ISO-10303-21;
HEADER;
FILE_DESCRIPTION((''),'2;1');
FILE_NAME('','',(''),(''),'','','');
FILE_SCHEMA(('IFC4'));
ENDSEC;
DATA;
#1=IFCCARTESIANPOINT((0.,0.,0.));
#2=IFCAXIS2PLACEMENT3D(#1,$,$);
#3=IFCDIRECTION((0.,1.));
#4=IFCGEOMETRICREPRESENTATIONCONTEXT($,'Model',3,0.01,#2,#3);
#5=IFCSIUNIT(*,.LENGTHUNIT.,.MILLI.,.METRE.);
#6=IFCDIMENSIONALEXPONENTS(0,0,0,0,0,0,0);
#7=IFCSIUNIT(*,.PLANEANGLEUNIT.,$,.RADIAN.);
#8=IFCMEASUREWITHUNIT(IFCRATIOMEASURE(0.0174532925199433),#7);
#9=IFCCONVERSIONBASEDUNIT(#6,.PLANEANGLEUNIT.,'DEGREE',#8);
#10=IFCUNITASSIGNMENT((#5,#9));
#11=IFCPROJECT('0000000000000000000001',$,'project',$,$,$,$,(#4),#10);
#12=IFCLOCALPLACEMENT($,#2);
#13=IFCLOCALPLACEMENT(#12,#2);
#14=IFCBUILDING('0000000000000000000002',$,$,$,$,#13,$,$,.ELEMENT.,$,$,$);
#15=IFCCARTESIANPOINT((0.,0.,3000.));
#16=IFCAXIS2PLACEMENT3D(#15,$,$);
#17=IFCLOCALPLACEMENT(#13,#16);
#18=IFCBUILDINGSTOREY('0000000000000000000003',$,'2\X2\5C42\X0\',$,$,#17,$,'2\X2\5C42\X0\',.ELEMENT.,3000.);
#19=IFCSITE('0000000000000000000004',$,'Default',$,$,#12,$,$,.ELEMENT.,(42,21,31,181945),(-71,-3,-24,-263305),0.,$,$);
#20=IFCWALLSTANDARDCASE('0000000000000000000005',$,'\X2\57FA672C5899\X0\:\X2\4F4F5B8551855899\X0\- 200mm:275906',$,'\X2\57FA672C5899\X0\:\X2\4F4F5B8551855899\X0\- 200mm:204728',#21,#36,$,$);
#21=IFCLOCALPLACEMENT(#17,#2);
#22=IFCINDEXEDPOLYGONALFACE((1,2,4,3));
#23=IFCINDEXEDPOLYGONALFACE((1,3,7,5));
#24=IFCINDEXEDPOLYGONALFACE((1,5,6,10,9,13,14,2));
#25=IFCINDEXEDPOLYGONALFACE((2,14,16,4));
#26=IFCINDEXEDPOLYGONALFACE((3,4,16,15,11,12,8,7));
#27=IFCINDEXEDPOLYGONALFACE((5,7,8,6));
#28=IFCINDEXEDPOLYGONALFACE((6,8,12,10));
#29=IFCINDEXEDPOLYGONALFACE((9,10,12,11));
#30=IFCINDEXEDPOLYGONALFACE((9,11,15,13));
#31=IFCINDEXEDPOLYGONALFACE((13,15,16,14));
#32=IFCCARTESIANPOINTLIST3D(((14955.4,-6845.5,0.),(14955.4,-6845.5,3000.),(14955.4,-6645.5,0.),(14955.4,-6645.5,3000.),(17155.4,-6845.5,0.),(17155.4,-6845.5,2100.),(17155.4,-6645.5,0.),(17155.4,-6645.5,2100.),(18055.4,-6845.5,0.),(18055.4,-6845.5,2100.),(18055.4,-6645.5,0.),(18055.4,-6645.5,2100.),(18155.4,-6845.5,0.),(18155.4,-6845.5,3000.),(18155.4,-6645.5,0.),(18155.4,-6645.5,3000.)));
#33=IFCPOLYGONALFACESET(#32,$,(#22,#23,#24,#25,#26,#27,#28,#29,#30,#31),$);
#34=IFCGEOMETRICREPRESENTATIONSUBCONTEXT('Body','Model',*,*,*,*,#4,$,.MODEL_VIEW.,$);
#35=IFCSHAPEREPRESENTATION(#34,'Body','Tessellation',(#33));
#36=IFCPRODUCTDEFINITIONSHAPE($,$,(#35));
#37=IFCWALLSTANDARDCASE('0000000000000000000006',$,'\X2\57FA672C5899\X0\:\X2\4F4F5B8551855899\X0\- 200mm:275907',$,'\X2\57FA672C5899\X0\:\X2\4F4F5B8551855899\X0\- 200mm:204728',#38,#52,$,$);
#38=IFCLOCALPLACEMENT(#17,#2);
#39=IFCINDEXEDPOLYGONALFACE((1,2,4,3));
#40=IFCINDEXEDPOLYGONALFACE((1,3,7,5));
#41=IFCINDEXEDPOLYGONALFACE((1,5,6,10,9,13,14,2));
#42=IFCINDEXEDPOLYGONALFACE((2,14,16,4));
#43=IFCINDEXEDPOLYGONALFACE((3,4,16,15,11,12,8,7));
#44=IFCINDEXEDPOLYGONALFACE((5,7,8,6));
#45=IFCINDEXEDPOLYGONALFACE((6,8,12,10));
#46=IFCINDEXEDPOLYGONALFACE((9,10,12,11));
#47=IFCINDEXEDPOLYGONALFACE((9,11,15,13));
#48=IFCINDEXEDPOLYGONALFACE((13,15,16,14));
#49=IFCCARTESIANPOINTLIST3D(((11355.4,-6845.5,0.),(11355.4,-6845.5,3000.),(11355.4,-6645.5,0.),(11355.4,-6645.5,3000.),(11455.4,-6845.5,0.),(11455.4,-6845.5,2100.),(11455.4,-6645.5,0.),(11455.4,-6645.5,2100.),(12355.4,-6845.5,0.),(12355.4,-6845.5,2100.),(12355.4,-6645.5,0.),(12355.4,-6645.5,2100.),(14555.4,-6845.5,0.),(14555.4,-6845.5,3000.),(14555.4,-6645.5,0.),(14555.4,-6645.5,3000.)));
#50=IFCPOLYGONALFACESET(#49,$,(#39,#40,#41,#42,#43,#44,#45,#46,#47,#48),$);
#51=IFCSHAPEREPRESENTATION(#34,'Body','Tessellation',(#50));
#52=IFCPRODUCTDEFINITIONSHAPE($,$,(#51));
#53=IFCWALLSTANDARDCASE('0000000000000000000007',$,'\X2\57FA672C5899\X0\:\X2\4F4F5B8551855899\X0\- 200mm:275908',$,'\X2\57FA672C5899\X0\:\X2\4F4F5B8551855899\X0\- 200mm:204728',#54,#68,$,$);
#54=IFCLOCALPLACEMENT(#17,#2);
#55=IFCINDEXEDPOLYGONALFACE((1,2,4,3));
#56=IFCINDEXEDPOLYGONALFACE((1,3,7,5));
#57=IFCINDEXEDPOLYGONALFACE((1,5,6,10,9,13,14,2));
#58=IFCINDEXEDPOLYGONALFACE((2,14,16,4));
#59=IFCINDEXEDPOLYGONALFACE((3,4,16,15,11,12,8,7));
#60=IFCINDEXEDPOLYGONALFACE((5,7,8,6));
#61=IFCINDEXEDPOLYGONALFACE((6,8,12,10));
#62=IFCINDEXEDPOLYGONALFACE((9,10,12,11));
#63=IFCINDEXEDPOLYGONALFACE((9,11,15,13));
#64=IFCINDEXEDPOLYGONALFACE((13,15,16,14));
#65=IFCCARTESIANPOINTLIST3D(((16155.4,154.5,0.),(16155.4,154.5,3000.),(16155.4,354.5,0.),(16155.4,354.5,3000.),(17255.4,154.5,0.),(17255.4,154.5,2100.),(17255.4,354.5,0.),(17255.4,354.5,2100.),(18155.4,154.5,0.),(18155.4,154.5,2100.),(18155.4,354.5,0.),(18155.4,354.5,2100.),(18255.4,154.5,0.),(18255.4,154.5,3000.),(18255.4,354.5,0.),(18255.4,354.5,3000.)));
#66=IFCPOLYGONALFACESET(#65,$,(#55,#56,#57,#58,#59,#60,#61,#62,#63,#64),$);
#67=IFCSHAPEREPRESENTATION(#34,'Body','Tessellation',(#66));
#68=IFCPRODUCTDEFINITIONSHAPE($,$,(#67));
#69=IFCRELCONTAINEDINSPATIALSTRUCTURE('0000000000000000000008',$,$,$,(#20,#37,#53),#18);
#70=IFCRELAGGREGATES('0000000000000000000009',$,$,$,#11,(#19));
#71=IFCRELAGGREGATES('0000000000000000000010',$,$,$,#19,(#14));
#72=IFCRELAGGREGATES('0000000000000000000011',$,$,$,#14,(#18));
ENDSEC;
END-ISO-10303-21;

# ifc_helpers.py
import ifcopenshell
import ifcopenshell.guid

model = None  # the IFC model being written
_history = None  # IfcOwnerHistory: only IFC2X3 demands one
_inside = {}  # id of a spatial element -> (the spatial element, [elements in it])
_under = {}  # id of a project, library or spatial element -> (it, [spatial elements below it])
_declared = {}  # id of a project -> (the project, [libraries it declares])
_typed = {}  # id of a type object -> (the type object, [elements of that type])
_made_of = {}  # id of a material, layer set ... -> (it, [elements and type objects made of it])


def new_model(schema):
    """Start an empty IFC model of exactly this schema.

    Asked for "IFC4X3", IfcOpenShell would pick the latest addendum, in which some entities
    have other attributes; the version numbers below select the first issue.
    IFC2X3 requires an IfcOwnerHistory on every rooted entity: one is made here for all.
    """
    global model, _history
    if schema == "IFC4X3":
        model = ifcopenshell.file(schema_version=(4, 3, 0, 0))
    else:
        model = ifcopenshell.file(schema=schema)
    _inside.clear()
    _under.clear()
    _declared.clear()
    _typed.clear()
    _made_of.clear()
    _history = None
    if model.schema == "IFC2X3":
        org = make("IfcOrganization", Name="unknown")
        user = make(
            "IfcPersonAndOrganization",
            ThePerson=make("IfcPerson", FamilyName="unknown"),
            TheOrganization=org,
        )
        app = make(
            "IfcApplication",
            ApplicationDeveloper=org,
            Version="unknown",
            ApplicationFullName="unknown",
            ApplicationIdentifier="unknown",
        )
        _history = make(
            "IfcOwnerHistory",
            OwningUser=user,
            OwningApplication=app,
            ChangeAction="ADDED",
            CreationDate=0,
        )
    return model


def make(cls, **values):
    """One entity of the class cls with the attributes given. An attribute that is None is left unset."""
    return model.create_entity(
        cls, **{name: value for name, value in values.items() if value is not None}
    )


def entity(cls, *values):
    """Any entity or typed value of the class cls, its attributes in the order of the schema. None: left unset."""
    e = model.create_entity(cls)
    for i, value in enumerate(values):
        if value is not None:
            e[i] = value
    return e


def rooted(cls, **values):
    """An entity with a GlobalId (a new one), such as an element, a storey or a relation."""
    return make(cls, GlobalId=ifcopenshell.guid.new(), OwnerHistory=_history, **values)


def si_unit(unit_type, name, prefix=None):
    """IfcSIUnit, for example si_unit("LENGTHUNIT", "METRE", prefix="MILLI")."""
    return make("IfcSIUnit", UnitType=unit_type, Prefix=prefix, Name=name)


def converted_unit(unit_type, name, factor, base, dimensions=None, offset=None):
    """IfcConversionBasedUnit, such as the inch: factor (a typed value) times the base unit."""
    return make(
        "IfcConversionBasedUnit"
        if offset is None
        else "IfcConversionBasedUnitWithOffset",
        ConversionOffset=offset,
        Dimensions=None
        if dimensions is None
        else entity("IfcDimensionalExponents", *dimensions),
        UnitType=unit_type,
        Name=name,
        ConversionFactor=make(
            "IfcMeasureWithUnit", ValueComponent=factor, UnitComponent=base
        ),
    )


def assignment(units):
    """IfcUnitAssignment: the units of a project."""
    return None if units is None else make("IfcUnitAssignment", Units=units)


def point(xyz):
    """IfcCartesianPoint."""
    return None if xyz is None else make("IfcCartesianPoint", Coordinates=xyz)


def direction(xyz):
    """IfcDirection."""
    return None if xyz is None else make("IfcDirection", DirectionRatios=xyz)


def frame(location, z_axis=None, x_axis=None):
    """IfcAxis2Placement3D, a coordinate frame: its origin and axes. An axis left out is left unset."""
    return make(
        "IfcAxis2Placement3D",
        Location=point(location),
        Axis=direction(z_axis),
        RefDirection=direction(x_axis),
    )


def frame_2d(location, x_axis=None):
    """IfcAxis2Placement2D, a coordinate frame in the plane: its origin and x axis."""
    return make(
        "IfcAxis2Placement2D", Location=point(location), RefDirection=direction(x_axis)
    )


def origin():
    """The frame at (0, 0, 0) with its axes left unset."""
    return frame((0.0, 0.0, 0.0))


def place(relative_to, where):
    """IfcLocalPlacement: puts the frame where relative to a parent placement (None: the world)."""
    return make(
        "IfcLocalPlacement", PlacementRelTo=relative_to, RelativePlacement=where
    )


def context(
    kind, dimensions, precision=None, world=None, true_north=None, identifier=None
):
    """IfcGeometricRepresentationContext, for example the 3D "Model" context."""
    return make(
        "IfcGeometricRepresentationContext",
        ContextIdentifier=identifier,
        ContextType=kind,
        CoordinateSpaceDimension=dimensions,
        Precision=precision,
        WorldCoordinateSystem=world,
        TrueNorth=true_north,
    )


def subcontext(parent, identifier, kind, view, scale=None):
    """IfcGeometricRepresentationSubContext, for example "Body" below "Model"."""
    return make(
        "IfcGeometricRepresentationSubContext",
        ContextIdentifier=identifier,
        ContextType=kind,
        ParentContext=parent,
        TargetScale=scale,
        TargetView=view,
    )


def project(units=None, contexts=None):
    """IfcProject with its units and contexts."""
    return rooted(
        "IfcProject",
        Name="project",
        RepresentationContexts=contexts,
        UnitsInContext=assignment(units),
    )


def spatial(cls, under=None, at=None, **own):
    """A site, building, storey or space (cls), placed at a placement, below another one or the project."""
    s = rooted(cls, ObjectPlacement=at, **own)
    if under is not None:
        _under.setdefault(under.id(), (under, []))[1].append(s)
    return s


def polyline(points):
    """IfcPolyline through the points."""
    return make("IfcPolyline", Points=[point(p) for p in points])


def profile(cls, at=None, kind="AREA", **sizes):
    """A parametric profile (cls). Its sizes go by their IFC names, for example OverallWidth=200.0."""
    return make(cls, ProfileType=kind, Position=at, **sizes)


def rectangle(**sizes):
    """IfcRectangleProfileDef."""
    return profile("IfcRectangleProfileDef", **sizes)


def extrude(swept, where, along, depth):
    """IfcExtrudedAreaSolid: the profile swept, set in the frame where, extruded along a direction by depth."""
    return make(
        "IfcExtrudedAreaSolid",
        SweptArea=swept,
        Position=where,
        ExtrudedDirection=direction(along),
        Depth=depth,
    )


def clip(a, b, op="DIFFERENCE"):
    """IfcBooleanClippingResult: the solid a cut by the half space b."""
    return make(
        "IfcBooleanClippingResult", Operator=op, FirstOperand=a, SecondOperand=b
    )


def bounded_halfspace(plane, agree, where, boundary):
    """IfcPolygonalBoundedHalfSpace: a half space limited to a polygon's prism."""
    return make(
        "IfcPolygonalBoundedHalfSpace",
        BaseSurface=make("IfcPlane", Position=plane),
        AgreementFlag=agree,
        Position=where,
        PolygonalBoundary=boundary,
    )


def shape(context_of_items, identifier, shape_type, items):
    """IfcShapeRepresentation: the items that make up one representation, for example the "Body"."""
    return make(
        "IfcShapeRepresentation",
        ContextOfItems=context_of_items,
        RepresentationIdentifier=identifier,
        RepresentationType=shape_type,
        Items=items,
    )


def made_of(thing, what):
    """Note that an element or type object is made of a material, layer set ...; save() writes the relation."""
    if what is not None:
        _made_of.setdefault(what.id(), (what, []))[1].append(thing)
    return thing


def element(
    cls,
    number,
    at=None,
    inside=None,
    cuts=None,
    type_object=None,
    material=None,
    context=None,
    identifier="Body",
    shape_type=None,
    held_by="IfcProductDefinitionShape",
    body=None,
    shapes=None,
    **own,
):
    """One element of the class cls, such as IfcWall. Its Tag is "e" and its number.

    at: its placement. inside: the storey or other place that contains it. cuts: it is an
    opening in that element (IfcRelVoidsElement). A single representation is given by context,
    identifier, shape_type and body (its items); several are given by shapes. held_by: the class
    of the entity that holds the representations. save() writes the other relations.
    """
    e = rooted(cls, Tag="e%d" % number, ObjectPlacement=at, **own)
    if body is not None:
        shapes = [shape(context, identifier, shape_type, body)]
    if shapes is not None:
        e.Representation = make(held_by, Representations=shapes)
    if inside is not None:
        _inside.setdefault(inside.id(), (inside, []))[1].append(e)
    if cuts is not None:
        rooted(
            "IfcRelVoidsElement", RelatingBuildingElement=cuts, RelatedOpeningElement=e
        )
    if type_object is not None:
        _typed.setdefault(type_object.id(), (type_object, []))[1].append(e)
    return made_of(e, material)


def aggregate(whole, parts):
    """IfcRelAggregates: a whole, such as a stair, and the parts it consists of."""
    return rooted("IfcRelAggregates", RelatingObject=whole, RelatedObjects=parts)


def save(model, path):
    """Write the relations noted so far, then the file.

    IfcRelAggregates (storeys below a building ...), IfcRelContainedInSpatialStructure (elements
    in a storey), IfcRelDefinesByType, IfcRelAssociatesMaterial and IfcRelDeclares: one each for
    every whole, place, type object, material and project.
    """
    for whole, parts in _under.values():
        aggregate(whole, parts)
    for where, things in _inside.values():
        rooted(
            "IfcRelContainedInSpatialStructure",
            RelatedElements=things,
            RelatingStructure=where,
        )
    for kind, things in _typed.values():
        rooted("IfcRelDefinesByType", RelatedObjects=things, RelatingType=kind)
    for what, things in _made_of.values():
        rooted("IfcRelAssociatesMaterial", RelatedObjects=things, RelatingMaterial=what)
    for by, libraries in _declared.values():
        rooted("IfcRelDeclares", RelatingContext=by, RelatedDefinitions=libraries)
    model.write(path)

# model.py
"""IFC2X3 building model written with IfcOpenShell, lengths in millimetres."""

from ifc_helpers import new_model, entity, si_unit, converted_unit, direction, frame, frame_2d, origin, place, context, subcontext, project, spatial, polyline, rectangle, extrude, clip, bounded_halfspace, element, save


model = new_model("IFC2X3")

# Units and contexts
model_context = context("Model", 3, precision=0.01, world=origin(), true_north=direction((0.0, 1.0)))
body_context = subcontext(model_context, "Body", "Model", "MODEL_VIEW")
ifc_project = project(units=[si_unit("LENGTHUNIT", "METRE", prefix="MILLI"), converted_unit("PLANEANGLEUNIT", "DEGREE", entity("IfcRatioMeasure", 0.0174532925199433), si_unit("PLANEANGLEUNIT", "RADIAN"), dimensions=[0, 0, 0, 0, 0, 0, 0])], contexts=[model_context])

# Site, building, storey
site_placement = place(None, origin())
site = spatial("IfcSite", under=ifc_project, at=site_placement, Name="Default", CompositionType="ELEMENT", RefLatitude=(42, 21, 31, 181945), RefLongitude=(-71, -3, -24, -263305), RefElevation=0.0)
building_placement = place(site_placement, origin())
building = spatial("IfcBuilding", under=site, at=building_placement, CompositionType="ELEMENT")
storey_placement = place(building_placement, frame((0.0, 0.0, 3000.0)))
storey = spatial("IfcBuildingStorey", under=building, at=storey_placement, Name="2层", LongName="2层", CompositionType="ELEMENT", Elevation=3000.0)

# Walls, openings
wall_1_placement = place(storey_placement, frame((18155.4, -6745.5, 0.0), z_axis=(0.0, 0.0, 1.0), x_axis=(-1.0, 0.0, 0.0)))
wall_1 = element("IfcWallStandardCase", 1, at=wall_1_placement, inside=storey, Name="基本墙:住宅内墙- 200mm:275906", ObjectType="基本墙:住宅内墙- 200mm:204728", context=body_context, shape_type="Clipping", body=[
    clip(clip(extrude(rectangle(XDim=3200.0, YDim=200.0, at=frame_2d((1600.0, 0.0), x_axis=(-1.0, 0.0))), origin(), (0.0, 0.0, 1.0), 3000.0), bounded_halfspace(frame((0.0, -100.0, 0.0), z_axis=(-1.0, 0.0, 0.0), x_axis=(0.0, 0.0, -1.0)), False, frame((0.0, -100.0, 0.0), z_axis=(-1.0, 0.0, 0.0), x_axis=(0.0, 0.0, -1.0)), polyline([(0.0, 0.0), (-3000.0, 0.0), (-3000.0, -200.0), (0.0, -200.0), (0.0, 0.0)]))), bounded_halfspace(frame((3200.0, -100.0, 3000.0), z_axis=(1.0, 0.0, 0.0), x_axis=(0.0, 0.0, -1.0)), False, frame((3200.0, -100.0, 3000.0), z_axis=(1.0, 0.0, 0.0), x_axis=(0.0, 0.0, -1.0)), polyline([(0.0, 0.0), (3000.0, 0.0), (3000.0, 200.0), (0.0, 200.0), (0.0, 0.0)]))),
])
opening_1_placement = place(wall_1_placement, frame((100.0, -100.0, 0.0)))
element("IfcOpeningElement", 2, at=opening_1_placement, cuts=wall_1, ObjectType="Opening", context=body_context, shape_type="SweptSolid", body=[
    extrude(rectangle(XDim=2100.0, YDim=900.0, at=frame_2d((1050.0, 450.0), x_axis=(1.0, 0.0))), frame((0.0, 0.0, 0.0), z_axis=(0.0, 1.0, 0.0), x_axis=(0.0, 0.0, 1.0)), (0.0, 0.0, 1.0), 200.0),
])
wall_2_placement = place(storey_placement, frame((11355.4, -6745.5, 0.0)))
wall_2 = element("IfcWallStandardCase", 3, at=wall_2_placement, inside=storey, Name="基本墙:住宅内墙- 200mm:275907", ObjectType="基本墙:住宅内墙- 200mm:204728", context=body_context, shape_type="Clipping", body=[
    clip(clip(extrude(rectangle(XDim=3200.0, YDim=200.0, at=frame_2d((1600.0, 0.0), x_axis=(-1.0, 0.0))), origin(), (0.0, 0.0, 1.0), 3000.0), bounded_halfspace(frame((0.0, -100.0, 0.0), z_axis=(1.0, 0.0, 0.0), x_axis=(0.0, 0.0, -1.0)), True, frame((0.0, -100.0, 0.0), z_axis=(1.0, 0.0, 0.0), x_axis=(0.0, 0.0, -1.0)), polyline([(0.0, 0.0), (0.0, 200.0), (-3000.0, 200.0), (-3000.0, 0.0), (0.0, 0.0)]))), bounded_halfspace(frame((3200.0, -100.0, 3000.0), z_axis=(1.0, 0.0, 0.0), x_axis=(0.0, 0.0, -1.0)), False, frame((3200.0, -100.0, 3000.0), z_axis=(1.0, 0.0, 0.0), x_axis=(0.0, 0.0, -1.0)), polyline([(0.0, 0.0), (3000.0, 0.0), (3000.0, 200.0), (0.0, 200.0), (0.0, 0.0)]))),
])
opening_2_placement = place(wall_2_placement, frame((1000.0, 100.0, 0.0)))
element("IfcOpeningElement", 4, at=opening_2_placement, cuts=wall_2, ObjectType="Opening", context=body_context, shape_type="SweptSolid", body=[
    extrude(rectangle(XDim=2100.0, YDim=900.0, at=frame_2d((1050.0, 450.0), x_axis=(1.0, 0.0))), frame((0.0, 0.0, 0.0), z_axis=(0.0, -1.0, 0.0), x_axis=(0.0, 0.0, 1.0)), (0.0, 0.0, 1.0), 200.0),
])
wall_3_placement = place(storey_placement, frame((18255.4, 254.5, 0.0), z_axis=(0.0, 0.0, 1.0), x_axis=(-1.0, 0.0, 0.0)))
wall_3 = element("IfcWallStandardCase", 5, at=wall_3_placement, inside=storey, Name="基本墙:住宅内墙- 200mm:275908", ObjectType="基本墙:住宅内墙- 200mm:204728", context=body_context, shape_type="SweptSolid", body=[
    extrude(rectangle(XDim=2100.0, YDim=200.0, at=frame_2d((1050.0, 0.0), x_axis=(-1.0, 0.0))), origin(), (0.0, 0.0, 1.0), 3000.0),
])
opening_3_placement = place(wall_3_placement, frame((1000.0, 100.0, 0.0)))
element("IfcOpeningElement", 6, at=opening_3_placement, cuts=wall_3, ObjectType="Opening", context=body_context, shape_type="SweptSolid", body=[
    extrude(rectangle(XDim=2100.0, YDim=900.0, at=frame_2d((1050.0, 450.0), x_axis=(1.0, 0.0))), frame((0.0, 0.0, 0.0), z_axis=(0.0, -1.0, 0.0), x_axis=(0.0, 0.0, 1.0)), (0.0, 0.0, 1.0), 200.0),
])

save(model, "model.ifc")
